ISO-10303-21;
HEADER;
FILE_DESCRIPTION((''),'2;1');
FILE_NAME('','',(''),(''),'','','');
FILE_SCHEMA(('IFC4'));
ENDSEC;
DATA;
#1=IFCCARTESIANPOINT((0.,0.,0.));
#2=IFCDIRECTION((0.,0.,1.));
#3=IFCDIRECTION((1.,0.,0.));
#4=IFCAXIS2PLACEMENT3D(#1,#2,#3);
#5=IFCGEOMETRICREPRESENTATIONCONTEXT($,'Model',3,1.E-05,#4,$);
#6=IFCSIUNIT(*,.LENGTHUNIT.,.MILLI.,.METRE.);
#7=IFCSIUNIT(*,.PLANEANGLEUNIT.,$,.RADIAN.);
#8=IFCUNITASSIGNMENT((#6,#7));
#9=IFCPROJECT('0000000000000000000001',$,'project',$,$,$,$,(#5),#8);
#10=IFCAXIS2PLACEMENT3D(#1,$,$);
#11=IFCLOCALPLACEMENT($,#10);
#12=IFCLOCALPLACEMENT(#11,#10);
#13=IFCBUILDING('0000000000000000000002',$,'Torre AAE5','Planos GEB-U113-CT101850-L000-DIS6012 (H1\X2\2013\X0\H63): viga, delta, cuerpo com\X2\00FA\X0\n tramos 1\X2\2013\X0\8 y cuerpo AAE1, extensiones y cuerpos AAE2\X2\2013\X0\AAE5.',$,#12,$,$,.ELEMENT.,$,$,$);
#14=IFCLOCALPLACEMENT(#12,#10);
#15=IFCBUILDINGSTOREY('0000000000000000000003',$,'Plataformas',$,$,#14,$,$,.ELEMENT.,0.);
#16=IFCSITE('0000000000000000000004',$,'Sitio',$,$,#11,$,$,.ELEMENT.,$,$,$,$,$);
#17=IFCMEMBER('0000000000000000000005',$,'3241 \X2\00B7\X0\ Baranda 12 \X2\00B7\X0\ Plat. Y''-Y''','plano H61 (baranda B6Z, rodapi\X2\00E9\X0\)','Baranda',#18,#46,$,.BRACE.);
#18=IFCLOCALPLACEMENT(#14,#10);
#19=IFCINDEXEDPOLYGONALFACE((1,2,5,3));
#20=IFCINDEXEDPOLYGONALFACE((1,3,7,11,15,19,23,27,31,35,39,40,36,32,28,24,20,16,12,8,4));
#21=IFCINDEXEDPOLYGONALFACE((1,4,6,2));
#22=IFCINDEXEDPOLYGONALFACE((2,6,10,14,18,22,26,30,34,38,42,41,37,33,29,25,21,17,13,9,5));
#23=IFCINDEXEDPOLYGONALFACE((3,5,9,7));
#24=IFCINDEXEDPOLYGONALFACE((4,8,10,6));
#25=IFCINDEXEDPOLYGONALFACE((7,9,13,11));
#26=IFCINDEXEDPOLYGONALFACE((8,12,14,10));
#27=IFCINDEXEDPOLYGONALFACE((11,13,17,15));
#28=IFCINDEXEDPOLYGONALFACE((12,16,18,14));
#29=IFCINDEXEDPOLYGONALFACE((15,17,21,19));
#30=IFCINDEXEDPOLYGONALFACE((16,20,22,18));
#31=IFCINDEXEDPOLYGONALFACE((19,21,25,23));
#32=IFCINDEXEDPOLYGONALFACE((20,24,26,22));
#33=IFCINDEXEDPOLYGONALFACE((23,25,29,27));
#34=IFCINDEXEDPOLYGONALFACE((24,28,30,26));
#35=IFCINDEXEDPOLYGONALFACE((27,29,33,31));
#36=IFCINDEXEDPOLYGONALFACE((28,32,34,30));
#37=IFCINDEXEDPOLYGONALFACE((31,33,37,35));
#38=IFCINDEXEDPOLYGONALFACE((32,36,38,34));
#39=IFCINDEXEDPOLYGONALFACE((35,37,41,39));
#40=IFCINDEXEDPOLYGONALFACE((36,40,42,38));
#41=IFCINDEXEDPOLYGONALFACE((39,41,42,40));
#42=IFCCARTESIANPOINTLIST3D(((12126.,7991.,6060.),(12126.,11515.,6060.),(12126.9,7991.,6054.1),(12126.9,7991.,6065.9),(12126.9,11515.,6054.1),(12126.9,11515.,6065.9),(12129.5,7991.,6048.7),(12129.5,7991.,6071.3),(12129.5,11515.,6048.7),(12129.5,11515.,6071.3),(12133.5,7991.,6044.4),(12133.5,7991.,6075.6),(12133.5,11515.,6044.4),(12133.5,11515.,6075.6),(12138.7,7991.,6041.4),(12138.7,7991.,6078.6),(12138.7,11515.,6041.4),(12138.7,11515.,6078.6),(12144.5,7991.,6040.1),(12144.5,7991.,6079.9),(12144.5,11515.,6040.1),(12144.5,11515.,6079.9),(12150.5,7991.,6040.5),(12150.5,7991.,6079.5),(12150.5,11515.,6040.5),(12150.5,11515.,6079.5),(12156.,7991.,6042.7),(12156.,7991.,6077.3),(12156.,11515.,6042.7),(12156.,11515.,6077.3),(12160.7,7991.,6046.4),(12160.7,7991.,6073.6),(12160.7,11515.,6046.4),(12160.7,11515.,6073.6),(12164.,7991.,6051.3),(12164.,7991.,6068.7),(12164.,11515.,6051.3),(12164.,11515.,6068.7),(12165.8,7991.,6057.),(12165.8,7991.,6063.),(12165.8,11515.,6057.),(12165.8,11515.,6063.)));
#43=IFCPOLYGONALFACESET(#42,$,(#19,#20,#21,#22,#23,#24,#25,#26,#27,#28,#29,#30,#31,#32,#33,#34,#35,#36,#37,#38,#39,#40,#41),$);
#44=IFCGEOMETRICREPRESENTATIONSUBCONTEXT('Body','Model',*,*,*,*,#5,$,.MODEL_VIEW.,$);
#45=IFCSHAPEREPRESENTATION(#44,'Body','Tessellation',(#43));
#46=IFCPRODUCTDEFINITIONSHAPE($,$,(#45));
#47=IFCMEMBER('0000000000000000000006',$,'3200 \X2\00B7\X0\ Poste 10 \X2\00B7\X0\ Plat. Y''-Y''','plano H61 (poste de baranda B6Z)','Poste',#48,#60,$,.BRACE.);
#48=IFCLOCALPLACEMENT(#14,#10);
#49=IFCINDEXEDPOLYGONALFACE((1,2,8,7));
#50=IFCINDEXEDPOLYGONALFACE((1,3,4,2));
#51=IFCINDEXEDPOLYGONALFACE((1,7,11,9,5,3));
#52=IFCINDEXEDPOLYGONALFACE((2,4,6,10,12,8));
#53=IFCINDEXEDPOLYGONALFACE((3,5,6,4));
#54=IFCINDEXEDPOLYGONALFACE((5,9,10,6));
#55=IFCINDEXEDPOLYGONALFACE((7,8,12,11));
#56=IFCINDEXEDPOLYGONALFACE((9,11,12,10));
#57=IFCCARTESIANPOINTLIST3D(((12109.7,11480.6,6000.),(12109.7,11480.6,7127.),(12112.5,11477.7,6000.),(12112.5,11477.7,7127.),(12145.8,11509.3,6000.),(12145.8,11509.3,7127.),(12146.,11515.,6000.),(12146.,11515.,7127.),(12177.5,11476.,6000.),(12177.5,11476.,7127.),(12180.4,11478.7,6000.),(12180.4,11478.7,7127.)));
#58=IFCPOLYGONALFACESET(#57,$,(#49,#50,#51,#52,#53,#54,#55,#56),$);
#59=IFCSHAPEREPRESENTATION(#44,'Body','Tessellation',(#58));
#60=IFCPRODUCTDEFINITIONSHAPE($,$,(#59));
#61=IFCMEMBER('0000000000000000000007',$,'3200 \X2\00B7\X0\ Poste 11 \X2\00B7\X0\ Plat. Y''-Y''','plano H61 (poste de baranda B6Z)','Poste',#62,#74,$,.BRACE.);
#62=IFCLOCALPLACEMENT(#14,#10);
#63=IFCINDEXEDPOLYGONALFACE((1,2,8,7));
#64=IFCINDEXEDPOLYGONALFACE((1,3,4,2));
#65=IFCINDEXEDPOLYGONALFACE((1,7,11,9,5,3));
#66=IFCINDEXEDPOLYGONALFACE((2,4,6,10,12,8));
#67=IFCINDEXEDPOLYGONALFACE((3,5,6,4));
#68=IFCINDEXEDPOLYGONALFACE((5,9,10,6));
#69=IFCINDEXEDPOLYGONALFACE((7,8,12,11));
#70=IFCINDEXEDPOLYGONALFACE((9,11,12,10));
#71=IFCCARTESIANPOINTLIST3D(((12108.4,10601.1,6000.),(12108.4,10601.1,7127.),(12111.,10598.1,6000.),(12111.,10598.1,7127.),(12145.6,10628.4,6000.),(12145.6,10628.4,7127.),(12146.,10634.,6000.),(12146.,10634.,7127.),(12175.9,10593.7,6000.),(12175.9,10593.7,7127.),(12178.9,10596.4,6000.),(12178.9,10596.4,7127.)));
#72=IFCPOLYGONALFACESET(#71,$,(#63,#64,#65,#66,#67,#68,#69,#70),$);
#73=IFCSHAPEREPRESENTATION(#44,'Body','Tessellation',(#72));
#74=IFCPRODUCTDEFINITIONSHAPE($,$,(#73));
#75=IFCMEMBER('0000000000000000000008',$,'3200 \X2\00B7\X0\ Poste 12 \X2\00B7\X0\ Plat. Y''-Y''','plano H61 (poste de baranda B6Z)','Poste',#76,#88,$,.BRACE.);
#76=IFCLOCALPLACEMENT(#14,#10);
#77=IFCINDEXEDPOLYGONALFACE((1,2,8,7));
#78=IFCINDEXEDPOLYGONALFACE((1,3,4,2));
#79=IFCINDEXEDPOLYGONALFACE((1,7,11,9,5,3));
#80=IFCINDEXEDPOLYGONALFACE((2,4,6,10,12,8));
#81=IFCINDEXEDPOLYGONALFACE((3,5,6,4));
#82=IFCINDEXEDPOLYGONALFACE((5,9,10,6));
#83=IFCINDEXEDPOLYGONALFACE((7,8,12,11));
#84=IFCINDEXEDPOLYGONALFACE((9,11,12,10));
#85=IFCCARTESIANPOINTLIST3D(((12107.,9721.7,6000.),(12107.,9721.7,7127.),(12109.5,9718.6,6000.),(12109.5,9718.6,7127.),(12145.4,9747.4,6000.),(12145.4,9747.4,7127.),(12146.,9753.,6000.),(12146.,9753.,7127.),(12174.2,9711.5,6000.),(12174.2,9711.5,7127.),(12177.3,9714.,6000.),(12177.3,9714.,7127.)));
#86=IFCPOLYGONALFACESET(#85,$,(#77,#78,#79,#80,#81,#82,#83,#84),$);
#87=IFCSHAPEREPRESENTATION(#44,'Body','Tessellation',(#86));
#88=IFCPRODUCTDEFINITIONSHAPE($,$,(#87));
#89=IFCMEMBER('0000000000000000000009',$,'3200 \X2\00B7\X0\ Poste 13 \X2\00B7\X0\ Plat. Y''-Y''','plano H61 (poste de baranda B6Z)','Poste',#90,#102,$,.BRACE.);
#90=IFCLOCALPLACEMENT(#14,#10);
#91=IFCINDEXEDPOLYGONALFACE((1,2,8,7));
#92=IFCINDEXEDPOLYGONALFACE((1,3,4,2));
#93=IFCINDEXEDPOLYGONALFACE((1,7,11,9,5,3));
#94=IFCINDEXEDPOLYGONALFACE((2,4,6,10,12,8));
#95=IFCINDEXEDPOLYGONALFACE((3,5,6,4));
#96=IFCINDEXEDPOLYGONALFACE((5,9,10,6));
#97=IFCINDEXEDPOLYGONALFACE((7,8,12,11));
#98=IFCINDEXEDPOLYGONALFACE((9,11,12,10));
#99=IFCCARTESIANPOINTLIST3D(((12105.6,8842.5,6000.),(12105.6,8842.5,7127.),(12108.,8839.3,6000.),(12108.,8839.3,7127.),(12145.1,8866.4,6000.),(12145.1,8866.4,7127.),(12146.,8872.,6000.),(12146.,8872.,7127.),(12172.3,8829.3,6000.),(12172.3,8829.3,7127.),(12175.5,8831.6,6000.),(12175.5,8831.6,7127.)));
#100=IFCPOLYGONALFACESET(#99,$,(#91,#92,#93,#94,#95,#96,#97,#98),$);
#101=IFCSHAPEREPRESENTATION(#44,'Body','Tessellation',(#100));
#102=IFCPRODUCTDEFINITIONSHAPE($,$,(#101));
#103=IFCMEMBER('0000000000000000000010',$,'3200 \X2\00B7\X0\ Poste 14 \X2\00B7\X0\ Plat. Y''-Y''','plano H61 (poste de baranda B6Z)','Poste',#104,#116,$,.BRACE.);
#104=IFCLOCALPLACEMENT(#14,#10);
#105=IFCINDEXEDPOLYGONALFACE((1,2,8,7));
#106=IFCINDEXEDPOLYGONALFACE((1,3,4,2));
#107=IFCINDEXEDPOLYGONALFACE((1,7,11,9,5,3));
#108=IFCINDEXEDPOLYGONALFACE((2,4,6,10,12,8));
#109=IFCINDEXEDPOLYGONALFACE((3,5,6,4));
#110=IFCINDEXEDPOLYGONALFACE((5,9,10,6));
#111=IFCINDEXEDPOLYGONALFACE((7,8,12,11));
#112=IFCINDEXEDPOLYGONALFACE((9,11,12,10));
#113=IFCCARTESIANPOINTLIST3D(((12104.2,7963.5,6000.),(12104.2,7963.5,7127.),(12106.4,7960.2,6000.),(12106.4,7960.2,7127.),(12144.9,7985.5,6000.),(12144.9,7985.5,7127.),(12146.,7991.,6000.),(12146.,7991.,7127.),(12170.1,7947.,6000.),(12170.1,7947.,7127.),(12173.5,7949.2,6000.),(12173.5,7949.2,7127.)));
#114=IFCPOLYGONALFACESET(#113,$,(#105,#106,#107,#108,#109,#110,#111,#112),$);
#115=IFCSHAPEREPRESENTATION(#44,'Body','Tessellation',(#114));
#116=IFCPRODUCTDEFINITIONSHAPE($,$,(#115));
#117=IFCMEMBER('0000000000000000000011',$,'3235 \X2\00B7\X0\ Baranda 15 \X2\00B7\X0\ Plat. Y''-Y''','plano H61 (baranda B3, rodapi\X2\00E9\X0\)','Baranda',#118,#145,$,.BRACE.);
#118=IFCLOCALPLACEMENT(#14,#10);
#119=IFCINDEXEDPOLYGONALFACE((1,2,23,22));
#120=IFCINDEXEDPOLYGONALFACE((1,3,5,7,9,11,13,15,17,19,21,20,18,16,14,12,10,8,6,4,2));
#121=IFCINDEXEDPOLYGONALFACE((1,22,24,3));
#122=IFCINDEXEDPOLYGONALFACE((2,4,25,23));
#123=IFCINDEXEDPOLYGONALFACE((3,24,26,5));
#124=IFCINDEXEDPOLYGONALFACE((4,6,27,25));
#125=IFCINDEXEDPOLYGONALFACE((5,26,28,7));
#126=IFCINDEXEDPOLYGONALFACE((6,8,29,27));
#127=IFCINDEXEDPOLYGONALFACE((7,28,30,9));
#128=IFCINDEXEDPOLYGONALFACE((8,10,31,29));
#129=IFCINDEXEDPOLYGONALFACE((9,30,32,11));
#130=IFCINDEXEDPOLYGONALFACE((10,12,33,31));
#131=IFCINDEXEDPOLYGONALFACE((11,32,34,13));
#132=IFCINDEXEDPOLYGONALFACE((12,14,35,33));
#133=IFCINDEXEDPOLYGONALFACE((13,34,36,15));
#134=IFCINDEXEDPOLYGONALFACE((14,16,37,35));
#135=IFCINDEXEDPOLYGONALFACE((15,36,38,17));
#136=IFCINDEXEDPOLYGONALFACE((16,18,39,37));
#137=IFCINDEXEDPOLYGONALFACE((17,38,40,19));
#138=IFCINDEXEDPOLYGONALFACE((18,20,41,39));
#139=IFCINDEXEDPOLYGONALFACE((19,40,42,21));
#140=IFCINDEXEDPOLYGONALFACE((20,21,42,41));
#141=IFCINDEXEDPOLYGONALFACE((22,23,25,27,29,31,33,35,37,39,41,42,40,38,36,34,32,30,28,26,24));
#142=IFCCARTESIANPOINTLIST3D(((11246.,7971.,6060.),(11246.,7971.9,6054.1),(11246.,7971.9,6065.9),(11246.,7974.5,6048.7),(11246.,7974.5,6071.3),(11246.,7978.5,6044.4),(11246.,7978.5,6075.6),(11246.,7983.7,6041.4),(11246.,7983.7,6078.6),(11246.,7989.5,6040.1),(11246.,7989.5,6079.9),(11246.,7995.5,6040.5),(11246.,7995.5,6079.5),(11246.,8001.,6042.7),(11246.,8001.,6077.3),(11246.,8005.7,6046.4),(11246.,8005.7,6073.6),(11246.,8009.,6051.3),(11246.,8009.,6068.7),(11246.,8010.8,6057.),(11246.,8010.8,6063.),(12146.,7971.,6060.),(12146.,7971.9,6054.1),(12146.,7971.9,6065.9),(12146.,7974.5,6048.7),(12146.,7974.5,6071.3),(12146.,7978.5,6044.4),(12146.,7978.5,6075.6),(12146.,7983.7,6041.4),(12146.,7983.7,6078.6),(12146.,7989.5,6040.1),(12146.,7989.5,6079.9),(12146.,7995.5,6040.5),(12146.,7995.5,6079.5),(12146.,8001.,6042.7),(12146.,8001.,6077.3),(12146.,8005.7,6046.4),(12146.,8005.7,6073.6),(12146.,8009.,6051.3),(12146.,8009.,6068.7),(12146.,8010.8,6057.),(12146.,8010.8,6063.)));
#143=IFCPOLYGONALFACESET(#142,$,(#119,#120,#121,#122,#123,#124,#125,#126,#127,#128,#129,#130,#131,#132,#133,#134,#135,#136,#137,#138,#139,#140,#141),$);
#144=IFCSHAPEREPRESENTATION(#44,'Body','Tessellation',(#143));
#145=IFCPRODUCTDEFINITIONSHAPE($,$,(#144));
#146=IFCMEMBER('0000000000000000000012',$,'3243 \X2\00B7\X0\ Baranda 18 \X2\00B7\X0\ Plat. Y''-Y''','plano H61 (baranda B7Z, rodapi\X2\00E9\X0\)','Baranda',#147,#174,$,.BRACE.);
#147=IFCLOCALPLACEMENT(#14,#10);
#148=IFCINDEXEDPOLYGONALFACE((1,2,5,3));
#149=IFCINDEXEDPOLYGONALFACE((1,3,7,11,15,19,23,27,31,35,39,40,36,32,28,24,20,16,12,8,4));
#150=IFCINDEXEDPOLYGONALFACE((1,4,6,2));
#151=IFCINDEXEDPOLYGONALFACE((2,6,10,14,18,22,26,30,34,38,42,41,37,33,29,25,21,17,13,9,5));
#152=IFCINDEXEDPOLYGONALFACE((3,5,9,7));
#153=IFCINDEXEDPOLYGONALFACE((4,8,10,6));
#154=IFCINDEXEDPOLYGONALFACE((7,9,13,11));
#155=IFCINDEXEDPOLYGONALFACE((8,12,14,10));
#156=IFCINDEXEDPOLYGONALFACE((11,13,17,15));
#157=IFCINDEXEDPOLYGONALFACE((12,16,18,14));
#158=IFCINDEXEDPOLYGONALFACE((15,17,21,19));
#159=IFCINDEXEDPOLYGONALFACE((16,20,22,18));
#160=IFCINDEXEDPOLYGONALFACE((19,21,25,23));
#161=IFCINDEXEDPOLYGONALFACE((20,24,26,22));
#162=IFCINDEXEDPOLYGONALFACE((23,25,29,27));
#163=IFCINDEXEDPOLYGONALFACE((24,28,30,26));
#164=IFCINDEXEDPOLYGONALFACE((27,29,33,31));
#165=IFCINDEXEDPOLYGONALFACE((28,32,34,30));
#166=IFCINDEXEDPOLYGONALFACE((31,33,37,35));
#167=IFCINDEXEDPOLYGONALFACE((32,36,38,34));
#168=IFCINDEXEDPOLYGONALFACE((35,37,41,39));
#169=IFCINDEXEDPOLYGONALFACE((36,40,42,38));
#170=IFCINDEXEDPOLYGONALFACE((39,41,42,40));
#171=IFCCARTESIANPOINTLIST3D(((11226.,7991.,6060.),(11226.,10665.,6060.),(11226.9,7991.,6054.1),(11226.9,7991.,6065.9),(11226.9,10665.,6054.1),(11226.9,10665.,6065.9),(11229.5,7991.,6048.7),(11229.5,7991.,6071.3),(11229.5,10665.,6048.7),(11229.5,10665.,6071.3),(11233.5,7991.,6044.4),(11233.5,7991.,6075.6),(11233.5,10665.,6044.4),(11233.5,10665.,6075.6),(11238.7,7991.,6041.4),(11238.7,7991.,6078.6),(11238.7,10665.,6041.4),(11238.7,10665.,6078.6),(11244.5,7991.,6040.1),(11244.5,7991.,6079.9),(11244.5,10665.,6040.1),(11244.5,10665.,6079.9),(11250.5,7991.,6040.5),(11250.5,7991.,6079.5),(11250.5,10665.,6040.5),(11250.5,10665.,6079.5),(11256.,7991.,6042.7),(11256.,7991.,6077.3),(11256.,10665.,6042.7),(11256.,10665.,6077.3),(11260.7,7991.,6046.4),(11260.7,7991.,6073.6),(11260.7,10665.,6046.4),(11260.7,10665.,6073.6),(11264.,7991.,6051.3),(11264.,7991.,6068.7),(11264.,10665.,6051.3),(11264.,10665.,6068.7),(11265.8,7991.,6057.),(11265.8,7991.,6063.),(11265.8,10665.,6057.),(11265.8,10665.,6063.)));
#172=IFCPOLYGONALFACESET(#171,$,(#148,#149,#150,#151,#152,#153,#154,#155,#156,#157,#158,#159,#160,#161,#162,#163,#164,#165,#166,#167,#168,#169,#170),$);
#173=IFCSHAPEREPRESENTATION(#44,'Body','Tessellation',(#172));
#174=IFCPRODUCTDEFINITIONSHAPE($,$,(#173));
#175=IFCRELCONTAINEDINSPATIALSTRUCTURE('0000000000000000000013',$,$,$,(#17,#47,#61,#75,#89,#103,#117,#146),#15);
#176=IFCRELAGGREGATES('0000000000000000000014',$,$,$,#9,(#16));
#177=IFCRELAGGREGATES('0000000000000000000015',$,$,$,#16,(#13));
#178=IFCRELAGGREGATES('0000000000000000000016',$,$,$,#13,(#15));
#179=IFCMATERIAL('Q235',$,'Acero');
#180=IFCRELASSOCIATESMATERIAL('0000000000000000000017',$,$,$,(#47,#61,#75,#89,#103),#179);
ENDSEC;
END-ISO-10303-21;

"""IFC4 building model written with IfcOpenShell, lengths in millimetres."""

from ifc_helpers import new_model, si_unit, frame, frame_2d, origin, origin_with_axes, place, context, subcontext, project, spatial, circle, l_section, extrude, material, element, save


model = new_model("IFC4")

# Units and contexts
model_context = context("Model", 3, precision=1e-05, world=origin_with_axes())
body_context = subcontext(model_context, "Body", "Model", "MODEL_VIEW")
ifc_project = project(units=[si_unit("LENGTHUNIT", "METRE", prefix="MILLI"), si_unit("PLANEANGLEUNIT", "RADIAN")], contexts=[model_context])

# Site, building, storey
site_placement = place(None, origin())
site = spatial("IfcSite", under=ifc_project, at=site_placement, Name="Sitio", CompositionType="ELEMENT")
building_placement = place(site_placement, origin())
building = spatial("IfcBuilding", under=site, at=building_placement, Name="Torre AAE5", Description="Planos GEB-U113-CT101850-L000-DIS6012 (H1–H63): viga, delta, cuerpo común tramos 1–8 y cuerpo AAE1, extensiones y cuerpos AAE2–AAE5.", CompositionType="ELEMENT")
storey_placement = place(building_placement, origin())
storey = spatial("IfcBuildingStorey", under=building, at=storey_placement, Name="Plataformas", CompositionType="ELEMENT", Elevation=0.0)

# Members
ifc_material = material(Name="Q235", Category="Acero")
member_1_placement = place(storey_placement, frame((12146.0, 11515.0, 6060.0), z_axis=(0.0, -1.0, 0.0), x_axis=(-1.0, 0.0, 0.0)))
element("IfcMember", 1, at=member_1_placement, inside=storey, Name="3241 · Baranda 12 · Plat. Y'-Y'", Description="plano H61 (baranda B6Z, rodapié)", ObjectType="Baranda", PredefinedType="BRACE", context=body_context, shape_type="SweptSolid", body=[
    extrude(circle(Radius=20.0), None, (0.0, 0.0, 1.0), 3524.0),
])
for number, where, z_axis, x_axis, name in (
    (2, (12146.0, 11515.0, 6000.0), (0.0, 0.0, 1.0), (-0.725706, -0.688005, 0.0), "3200 · Poste 10 · Plat. Y'-Y'"),
    (3, (12146.0, 10634.0, 6000.0), (0.0, 0.0, 1.0), (-0.752385, -0.658724, 0.0), "3200 · Poste 11 · Plat. Y'-Y'"),
    (4, (12146.0, 9753.0, 6000.0), (0.0, 0.0, 1.0), (-0.779734, -0.626111, 0.0), "3200 · Poste 12 · Plat. Y'-Y'"),
    (5, (12146.0, 8872.0, 6000.0), (0.0, 0.0, 1.0), (-0.807515, -0.589847, 0.0), "3200 · Poste 13 · Plat. Y'-Y'"),
    (6, (12146.0, 7991.0, 6000.0), (0.0, 0.0, 1.0), (-0.83541, -0.549627, 0.0), "3200 · Poste 14 · Plat. Y'-Y'"),
):
    element("IfcMember", number, at=place(storey_placement, frame(where, z_axis=z_axis, x_axis=x_axis)), inside=storey, material=ifc_material, Name=name, Description="plano H61 (poste de baranda B6Z)", ObjectType="Poste", PredefinedType="BRACE", context=body_context, shape_type="SweptSolid", body=[
        extrude(l_section(Depth=50.0, Width=50.0, Thickness=4.0, at=frame_2d((25.0, 25.0))), None, (0.0, 0.0, 1.0), 1127.0),
    ])
member_2_placement = place(storey_placement, frame((12146.0, 7991.0, 6060.0), z_axis=(-1.0, 0.0, 0.0), x_axis=(0.0, -1.0, 0.0)))
element("IfcMember", 7, at=member_2_placement, inside=storey, Name="3235 · Baranda 15 · Plat. Y'-Y'", Description="plano H61 (baranda B3, rodapié)", ObjectType="Baranda", PredefinedType="BRACE", context=body_context, shape_type="SweptSolid", body=[
    extrude(circle(Radius=20.0), None, (0.0, 0.0, 1.0), 900.0),
])
member_3_placement = place(storey_placement, frame((11246.0, 7991.0, 6060.0), z_axis=(0.0, 1.0, 0.0), x_axis=(-1.0, 0.0, 0.0)))
element("IfcMember", 8, at=member_3_placement, inside=storey, Name="3243 · Baranda 18 · Plat. Y'-Y'", Description="plano H61 (baranda B7Z, rodapié)", ObjectType="Baranda", PredefinedType="BRACE", context=body_context, shape_type="SweptSolid", body=[
    extrude(circle(Radius=20.0), None, (0.0, 0.0, 1.0), 2674.0),
])

save(model, "model.ifc")
